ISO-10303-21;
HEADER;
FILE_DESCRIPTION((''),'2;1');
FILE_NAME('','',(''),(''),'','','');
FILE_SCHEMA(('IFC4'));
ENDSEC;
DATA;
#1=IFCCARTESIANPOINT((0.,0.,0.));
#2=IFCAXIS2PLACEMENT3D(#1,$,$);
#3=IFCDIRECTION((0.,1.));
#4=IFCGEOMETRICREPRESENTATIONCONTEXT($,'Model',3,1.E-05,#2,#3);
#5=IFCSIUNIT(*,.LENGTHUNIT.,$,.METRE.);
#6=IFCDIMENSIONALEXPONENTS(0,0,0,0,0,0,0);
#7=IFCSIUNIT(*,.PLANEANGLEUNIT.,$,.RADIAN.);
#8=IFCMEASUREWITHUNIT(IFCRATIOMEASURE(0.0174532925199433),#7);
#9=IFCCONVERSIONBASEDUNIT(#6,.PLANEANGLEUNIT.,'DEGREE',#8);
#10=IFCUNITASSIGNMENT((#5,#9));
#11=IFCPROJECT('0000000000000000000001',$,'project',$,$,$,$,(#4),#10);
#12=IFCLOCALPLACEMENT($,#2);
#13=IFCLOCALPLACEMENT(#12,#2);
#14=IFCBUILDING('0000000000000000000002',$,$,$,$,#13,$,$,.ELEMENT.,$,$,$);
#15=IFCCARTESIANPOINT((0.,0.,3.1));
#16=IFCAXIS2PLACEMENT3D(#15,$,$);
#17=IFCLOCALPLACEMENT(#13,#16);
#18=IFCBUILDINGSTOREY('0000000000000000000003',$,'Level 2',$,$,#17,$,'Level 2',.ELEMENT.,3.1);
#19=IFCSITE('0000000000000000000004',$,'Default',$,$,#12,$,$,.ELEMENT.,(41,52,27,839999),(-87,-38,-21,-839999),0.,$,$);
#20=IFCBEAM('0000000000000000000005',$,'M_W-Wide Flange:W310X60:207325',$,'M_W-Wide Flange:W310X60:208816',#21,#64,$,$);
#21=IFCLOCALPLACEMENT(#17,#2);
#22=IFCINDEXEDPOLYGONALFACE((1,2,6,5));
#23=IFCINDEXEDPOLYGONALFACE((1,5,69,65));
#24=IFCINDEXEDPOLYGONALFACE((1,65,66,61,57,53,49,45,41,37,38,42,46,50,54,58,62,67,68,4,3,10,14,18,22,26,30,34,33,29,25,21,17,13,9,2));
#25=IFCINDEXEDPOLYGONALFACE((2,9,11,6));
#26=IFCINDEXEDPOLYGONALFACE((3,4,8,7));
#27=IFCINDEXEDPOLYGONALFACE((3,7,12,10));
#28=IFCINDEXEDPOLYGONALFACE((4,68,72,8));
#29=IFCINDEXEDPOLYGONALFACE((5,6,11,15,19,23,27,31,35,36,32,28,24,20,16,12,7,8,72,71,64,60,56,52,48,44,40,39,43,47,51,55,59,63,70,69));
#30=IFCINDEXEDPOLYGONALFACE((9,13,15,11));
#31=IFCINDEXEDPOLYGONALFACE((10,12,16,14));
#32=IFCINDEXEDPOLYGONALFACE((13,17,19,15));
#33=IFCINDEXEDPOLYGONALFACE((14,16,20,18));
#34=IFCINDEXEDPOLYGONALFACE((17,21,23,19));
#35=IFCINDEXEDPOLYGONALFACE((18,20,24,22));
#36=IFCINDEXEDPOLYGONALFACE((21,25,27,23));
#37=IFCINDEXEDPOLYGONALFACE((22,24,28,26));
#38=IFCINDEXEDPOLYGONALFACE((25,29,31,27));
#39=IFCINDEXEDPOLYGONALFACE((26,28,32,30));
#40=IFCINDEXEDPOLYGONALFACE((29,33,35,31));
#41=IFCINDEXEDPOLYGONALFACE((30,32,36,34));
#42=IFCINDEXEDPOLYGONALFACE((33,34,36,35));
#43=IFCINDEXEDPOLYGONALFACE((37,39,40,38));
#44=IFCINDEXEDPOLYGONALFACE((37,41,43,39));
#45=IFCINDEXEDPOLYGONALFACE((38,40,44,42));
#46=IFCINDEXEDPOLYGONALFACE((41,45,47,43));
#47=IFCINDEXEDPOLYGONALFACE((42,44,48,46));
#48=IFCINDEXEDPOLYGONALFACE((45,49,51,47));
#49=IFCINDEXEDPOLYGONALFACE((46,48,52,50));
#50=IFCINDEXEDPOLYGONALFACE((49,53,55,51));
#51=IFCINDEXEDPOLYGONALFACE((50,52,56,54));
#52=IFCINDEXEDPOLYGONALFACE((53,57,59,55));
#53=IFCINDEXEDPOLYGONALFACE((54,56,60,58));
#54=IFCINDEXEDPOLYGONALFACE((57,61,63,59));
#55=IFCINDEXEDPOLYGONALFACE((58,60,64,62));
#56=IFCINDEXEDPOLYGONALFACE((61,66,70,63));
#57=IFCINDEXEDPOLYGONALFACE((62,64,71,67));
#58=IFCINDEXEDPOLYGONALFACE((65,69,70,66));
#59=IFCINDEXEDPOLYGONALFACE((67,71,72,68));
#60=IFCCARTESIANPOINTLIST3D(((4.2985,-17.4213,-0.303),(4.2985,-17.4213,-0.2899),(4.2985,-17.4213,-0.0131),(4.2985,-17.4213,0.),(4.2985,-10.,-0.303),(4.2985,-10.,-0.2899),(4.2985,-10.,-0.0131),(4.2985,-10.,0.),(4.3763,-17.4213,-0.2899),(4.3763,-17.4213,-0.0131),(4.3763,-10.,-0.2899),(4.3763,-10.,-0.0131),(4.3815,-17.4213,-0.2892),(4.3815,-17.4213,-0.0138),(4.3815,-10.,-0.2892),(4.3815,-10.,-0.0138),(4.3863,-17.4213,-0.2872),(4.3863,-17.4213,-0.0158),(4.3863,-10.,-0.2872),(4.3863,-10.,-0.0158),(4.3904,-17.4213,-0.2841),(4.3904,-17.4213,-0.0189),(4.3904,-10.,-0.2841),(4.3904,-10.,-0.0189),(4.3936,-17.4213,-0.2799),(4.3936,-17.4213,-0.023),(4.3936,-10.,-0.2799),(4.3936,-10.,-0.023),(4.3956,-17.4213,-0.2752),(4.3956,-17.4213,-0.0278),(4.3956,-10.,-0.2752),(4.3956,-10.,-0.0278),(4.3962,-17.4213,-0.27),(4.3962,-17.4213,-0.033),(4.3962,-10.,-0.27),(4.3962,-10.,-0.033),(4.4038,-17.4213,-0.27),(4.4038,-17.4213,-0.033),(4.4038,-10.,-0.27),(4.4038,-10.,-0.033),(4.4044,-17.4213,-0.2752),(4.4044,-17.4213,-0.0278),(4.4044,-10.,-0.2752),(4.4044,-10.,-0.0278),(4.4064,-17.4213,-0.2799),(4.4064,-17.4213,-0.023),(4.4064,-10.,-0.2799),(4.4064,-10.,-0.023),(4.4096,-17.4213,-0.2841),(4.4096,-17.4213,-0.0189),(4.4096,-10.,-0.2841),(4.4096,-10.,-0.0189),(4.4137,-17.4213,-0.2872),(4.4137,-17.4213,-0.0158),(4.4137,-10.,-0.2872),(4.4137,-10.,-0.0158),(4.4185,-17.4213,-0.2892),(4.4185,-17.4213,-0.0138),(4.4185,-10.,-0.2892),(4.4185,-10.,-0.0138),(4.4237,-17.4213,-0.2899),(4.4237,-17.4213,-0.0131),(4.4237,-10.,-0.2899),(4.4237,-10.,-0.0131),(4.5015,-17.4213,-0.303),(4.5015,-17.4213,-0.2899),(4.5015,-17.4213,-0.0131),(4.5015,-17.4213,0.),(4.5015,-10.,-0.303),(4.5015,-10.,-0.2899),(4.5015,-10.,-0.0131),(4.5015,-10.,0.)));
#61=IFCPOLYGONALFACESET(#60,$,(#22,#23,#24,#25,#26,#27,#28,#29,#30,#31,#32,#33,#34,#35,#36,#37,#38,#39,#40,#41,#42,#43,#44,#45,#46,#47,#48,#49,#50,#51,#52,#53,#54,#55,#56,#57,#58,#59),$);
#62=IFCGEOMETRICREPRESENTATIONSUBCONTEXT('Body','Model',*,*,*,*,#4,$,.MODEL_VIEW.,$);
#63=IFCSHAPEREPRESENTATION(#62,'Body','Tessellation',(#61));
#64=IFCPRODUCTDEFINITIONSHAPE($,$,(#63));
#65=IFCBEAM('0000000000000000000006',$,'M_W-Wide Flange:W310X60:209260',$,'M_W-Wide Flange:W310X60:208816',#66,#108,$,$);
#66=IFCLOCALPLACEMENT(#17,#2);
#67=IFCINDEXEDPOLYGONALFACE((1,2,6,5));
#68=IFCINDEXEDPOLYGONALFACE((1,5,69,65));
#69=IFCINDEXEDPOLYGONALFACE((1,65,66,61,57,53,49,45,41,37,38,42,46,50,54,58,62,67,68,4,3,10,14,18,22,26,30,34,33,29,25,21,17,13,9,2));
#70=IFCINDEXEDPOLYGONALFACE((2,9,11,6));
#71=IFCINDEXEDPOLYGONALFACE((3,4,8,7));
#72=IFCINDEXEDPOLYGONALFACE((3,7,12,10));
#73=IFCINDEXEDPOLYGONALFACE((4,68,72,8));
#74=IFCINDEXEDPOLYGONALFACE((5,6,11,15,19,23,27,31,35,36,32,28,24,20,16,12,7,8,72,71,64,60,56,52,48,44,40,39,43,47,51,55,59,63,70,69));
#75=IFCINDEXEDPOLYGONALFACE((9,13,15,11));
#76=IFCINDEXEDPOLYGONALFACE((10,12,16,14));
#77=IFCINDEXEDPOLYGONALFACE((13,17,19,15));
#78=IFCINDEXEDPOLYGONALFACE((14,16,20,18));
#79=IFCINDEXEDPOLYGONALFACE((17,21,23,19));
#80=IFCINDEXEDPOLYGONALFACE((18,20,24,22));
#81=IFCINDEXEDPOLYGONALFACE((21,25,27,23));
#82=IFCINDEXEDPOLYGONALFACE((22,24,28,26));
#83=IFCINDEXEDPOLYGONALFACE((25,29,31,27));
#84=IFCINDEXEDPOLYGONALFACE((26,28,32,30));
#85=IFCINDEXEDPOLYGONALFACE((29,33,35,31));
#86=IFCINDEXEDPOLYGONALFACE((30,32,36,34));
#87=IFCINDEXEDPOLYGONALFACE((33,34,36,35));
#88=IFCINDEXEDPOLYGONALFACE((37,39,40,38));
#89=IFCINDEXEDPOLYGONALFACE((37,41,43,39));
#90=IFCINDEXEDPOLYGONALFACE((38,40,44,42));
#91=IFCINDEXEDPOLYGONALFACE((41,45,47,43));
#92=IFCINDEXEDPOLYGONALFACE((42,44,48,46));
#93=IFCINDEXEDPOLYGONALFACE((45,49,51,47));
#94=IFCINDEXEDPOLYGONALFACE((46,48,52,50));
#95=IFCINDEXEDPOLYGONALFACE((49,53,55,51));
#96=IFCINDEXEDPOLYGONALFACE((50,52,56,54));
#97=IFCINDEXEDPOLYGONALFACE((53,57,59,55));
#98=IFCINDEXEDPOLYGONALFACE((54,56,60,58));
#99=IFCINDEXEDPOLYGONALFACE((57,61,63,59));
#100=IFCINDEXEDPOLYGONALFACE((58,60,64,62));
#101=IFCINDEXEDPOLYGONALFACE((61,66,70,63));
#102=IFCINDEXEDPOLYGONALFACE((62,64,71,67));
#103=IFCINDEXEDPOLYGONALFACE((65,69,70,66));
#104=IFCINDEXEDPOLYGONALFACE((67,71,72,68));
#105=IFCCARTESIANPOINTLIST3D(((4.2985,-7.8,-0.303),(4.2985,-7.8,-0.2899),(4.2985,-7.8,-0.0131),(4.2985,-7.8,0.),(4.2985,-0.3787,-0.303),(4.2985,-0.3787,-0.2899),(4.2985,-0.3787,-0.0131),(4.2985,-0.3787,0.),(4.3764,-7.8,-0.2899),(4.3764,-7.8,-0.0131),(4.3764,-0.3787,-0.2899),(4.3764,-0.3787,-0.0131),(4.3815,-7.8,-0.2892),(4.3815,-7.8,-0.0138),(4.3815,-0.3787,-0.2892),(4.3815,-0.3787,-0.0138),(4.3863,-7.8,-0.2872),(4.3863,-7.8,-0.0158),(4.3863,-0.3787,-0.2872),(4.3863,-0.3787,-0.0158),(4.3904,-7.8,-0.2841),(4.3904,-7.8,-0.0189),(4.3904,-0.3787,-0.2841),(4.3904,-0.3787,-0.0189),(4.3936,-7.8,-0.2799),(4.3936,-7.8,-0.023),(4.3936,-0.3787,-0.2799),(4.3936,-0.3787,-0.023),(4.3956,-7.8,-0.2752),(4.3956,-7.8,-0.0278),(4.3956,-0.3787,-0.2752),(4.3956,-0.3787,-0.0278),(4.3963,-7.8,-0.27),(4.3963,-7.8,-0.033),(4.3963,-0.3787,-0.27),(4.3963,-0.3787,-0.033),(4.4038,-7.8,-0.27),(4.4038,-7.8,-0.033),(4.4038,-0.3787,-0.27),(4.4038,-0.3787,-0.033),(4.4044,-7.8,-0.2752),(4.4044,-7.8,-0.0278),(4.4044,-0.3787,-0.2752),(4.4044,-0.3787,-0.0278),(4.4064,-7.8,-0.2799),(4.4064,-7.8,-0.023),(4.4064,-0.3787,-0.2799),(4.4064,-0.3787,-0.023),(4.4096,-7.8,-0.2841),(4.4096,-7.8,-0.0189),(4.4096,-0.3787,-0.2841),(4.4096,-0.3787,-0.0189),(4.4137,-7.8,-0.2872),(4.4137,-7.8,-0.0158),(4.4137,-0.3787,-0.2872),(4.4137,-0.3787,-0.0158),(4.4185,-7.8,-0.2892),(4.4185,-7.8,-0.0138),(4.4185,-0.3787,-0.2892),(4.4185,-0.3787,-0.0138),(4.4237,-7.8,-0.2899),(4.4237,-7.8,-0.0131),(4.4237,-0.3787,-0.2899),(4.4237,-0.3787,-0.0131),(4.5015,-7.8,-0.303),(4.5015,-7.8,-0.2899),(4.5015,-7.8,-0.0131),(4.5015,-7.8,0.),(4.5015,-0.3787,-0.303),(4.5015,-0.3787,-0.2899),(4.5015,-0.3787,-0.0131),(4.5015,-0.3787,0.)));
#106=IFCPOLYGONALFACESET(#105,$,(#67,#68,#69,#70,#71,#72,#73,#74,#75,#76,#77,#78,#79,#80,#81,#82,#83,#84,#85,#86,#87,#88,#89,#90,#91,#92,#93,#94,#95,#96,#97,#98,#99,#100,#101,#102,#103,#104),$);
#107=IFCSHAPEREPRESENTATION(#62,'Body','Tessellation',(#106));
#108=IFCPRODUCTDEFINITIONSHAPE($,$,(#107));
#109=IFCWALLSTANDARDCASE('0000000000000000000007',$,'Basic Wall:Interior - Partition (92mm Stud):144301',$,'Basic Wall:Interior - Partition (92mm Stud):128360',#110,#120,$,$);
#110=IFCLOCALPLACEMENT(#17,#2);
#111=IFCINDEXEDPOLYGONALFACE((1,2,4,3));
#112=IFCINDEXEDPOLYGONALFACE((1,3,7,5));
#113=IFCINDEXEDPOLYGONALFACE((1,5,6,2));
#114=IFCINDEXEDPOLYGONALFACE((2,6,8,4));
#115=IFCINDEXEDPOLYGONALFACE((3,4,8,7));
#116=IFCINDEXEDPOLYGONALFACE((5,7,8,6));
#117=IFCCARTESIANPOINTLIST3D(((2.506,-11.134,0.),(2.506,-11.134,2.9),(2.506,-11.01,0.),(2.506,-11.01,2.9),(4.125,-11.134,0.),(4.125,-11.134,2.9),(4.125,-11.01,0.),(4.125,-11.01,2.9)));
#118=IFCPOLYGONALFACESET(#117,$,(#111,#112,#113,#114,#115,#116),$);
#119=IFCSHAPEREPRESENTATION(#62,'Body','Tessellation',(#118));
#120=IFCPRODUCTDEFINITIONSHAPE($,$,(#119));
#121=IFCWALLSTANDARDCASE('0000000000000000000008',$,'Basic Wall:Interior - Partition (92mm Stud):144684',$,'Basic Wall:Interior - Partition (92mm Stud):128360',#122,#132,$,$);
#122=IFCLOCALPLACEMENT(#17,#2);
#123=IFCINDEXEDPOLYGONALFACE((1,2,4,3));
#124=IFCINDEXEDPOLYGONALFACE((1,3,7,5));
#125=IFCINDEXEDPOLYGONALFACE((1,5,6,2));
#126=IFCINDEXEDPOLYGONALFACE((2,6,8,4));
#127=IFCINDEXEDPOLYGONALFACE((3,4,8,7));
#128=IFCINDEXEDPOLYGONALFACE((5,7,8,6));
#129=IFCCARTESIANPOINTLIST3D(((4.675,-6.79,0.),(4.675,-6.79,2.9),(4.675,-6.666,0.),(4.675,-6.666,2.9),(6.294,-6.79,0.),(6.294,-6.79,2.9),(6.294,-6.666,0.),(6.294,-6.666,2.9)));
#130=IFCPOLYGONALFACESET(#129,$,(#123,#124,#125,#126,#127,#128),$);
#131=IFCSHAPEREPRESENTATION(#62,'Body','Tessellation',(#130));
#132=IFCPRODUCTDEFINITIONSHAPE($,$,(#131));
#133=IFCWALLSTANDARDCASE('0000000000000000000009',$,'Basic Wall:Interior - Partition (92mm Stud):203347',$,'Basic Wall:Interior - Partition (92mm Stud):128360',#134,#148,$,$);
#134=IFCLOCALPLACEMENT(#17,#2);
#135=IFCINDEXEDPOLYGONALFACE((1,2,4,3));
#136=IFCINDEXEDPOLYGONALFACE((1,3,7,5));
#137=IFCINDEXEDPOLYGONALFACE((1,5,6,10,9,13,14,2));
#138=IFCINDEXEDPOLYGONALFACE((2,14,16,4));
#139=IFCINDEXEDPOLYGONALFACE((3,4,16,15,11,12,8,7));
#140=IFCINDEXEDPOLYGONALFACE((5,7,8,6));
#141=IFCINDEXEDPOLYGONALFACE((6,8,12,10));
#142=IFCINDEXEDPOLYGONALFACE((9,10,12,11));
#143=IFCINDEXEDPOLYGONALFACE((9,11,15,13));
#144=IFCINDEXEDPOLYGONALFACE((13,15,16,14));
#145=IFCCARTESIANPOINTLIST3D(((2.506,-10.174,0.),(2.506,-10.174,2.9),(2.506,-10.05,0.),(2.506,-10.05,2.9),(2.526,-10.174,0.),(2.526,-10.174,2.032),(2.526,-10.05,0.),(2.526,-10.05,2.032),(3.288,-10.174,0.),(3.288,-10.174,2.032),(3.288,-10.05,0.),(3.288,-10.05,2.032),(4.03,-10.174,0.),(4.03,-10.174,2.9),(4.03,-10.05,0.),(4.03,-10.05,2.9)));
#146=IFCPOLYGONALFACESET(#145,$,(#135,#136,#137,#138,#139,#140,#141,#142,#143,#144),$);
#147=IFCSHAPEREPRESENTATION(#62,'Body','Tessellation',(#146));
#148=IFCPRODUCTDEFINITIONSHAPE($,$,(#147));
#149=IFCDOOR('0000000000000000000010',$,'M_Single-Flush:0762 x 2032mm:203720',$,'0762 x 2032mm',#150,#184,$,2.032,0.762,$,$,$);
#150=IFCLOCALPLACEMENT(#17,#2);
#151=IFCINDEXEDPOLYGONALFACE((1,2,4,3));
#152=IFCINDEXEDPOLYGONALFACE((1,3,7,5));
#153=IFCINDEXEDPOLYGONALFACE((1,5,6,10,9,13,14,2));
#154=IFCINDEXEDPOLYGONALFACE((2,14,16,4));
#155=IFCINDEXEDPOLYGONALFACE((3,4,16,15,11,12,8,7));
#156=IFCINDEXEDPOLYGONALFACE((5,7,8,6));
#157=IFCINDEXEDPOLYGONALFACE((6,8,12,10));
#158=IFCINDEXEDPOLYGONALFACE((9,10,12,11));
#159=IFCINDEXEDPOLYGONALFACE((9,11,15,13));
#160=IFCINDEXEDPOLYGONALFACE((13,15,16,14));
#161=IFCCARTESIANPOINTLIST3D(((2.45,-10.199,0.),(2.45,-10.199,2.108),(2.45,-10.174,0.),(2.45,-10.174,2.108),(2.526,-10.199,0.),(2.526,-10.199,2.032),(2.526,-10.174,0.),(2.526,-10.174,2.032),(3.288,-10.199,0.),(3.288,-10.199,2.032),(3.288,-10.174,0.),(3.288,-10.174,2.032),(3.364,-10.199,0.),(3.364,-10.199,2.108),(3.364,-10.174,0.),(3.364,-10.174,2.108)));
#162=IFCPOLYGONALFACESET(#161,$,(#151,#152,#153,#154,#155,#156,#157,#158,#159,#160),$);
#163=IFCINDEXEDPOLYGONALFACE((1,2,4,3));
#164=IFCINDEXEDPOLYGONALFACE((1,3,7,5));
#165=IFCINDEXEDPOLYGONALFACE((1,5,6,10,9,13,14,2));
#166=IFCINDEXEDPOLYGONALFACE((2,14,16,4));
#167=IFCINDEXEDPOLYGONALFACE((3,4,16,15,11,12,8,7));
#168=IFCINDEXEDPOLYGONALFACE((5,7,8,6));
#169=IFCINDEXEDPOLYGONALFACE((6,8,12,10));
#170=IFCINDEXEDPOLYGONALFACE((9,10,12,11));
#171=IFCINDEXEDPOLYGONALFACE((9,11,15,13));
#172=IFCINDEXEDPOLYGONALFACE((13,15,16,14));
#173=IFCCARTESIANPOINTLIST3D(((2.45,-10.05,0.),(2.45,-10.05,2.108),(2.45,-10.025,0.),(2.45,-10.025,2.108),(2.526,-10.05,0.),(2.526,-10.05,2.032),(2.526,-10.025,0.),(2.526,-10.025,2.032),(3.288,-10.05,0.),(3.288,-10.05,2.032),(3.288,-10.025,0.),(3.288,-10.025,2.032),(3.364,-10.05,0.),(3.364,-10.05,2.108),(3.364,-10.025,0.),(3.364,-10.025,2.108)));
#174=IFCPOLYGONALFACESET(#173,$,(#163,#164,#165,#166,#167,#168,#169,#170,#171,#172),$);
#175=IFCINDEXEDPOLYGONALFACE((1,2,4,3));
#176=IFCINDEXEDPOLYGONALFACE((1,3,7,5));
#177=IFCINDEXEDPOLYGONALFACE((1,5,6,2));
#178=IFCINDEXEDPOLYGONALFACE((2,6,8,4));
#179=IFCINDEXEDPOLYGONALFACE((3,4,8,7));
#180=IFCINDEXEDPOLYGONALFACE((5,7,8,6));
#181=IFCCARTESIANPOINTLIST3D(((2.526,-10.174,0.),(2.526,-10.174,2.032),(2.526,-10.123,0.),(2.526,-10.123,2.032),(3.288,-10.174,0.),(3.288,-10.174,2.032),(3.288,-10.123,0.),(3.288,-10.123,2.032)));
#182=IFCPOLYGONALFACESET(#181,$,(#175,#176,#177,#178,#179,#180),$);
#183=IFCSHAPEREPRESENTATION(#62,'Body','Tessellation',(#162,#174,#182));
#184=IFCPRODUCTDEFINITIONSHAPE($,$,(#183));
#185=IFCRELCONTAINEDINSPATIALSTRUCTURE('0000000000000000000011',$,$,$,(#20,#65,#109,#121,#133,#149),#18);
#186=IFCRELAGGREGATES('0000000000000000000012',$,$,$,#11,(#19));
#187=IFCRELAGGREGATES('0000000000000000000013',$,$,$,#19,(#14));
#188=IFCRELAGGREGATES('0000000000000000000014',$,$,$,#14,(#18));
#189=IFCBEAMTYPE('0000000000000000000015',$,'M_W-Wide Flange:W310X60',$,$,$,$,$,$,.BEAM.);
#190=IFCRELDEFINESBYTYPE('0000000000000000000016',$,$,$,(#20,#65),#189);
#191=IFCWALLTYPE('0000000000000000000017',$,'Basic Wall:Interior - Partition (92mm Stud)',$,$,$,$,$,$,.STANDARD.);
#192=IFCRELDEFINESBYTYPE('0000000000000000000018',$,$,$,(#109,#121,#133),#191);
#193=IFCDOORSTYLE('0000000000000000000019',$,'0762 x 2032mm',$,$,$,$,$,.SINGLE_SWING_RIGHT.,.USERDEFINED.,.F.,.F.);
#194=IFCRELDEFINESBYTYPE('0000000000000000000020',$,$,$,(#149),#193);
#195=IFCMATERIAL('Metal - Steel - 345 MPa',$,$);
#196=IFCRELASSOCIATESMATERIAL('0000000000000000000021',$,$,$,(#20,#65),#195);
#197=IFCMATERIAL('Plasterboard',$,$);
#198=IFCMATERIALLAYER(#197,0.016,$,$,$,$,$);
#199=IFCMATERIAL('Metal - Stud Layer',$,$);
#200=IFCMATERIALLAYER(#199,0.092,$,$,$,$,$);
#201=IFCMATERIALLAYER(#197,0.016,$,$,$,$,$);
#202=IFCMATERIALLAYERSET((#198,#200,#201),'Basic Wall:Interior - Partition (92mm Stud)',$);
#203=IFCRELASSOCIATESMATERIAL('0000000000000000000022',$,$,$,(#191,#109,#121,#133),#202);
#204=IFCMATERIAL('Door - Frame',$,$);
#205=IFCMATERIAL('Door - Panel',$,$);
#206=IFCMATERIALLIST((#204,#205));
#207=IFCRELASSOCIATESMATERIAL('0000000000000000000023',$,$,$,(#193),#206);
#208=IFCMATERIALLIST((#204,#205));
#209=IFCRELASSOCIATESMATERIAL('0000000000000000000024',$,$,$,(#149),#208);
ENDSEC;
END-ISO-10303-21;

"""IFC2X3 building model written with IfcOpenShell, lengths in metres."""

from ifc_helpers import new_model, entity, si_unit, converted_unit, direction, frame, frame_2d, origin, origin_2d_with_axis, place, context, subcontext, project, spatial, polyline, rectangle, i_section, outline, extrude, source, transform, mapped, material, material_list, layer, layer_set, layer_usage, type_object, type_shapes, element, fill, save


model = new_model("IFC2X3")

# Units and contexts
model_context = context("Model", 3, precision=1e-05, world=origin(), true_north=direction((0.0, 1.0)))
body_context = subcontext(model_context, "Body", "Model", "MODEL_VIEW")
ifc_project = project(units=[si_unit("LENGTHUNIT", "METRE"), converted_unit("PLANEANGLEUNIT", "DEGREE", entity("IfcRatioMeasure", 0.0174532925199433), si_unit("PLANEANGLEUNIT", "RADIAN"), dimensions=[0, 0, 0, 0, 0, 0, 0])], contexts=[model_context])

# Site, building, storey
site_placement = place(None, origin())
site = spatial("IfcSite", under=ifc_project, at=site_placement, Name="Default", CompositionType="ELEMENT", RefLatitude=(41, 52, 27, 839999), RefLongitude=(-87, -38, -21, -839999), RefElevation=0.0)
building_placement = place(site_placement, origin())
building = spatial("IfcBuilding", under=site, at=building_placement, CompositionType="ELEMENT")
storey_placement = place(building_placement, frame((0.0, 0.0, 3.1)))
storey = spatial("IfcBuildingStorey", under=building, at=storey_placement, Name="Level 2", LongName="Level 2", CompositionType="ELEMENT", Elevation=3.1)

# Beams
ifc_material_1 = material(Name="Metal - Steel - 345 MPa")
beam_type = type_object("IfcBeamType", Name="M_W-Wide Flange:W310X60", PredefinedType="BEAM")
beam_1_placement = place(storey_placement, frame((4.4, -10.0, 0.0), z_axis=(0.0, 0.0, 1.0), x_axis=(0.0, -1.0, 0.0)))
element("IfcBeam", 1, at=beam_1_placement, inside=storey, type_object=beam_type, material=ifc_material_1, Name="M_W-Wide Flange:W310X60:207325", ObjectType="M_W-Wide Flange:W310X60:208816", context=body_context, shape_type="SweptSolid", body=[
    extrude(i_section(OverallWidth=0.203, OverallDepth=0.303, WebThickness=0.0075, FlangeThickness=0.0131, FilletRadius=0.0199, at=frame_2d((0.0, 0.0), x_axis=(0.0, 1.0))), frame((0.0, 0.0, -0.1515), z_axis=(1.0, 0.0, 0.0), x_axis=(0.0, 0.0, -1.0)), (0.0, 0.0, 1.0), 7.4213),
])
beam_2_placement = place(storey_placement, frame((4.4, -7.8, 0.0), z_axis=(0.0, 0.0, 1.0), x_axis=(0.0, 1.0, 0.0)))
element("IfcBeam", 2, at=beam_2_placement, inside=storey, type_object=beam_type, material=ifc_material_1, Name="M_W-Wide Flange:W310X60:209260", ObjectType="M_W-Wide Flange:W310X60:208816", context=body_context, shape_type="SweptSolid", body=[
    extrude(i_section(OverallWidth=0.203, OverallDepth=0.303, WebThickness=0.0075, FlangeThickness=0.0131, FilletRadius=0.0199, at=frame_2d((0.0, 0.0), x_axis=(0.0, 1.0))), frame((0.0, 0.0, -0.1515), z_axis=(1.0, 0.0, 0.0), x_axis=(0.0, 0.0, -1.0)), (0.0, 0.0, 1.0), 7.4213),
])

# Walls
ifc_material_2 = material(Name="Plasterboard")
ifc_layer_1 = layer(ifc_material_2, 0.016)
ifc_material_3 = material(Name="Metal - Stud Layer")
ifc_layer_2 = layer(ifc_material_3, 0.092)
ifc_layer_3 = layer(ifc_material_2, 0.016)
ifc_layer_set_1 = layer_set([ifc_layer_1, ifc_layer_2, ifc_layer_3], Name="Basic Wall:Interior - Partition (92mm Stud)")
ifc_layer_usage_1 = layer_usage(ifc_layer_set_1, "AXIS2", "NEGATIVE", 0.062)
wall_type_1 = type_object("IfcWallType", Name="Basic Wall:Interior - Partition (92mm Stud)", PredefinedType="STANDARD", material=ifc_layer_set_1)
wall_1_placement = place(storey_placement, frame((4.125, -11.072, 0.0), z_axis=(0.0, 0.0, 1.0), x_axis=(-1.0, 0.0, 0.0)))
element("IfcWallStandardCase", 3, at=wall_1_placement, inside=storey, type_object=wall_type_1, material=ifc_layer_usage_1, Name="Basic Wall:Interior - Partition (92mm Stud):144301", ObjectType="Basic Wall:Interior - Partition (92mm Stud):128360", context=body_context, shape_type="SweptSolid", body=[
    extrude(rectangle(XDim=1.619, YDim=0.124, at=frame_2d((0.8095, 0.0), x_axis=(-1.0, 0.0))), origin(), (0.0, 0.0, 1.0), 2.9),
])
ifc_layer_usage_2 = layer_usage(ifc_layer_set_1, "AXIS2", "NEGATIVE", 0.062)
wall_2_placement = place(storey_placement, frame((4.675, -6.728, 0.0)))
element("IfcWallStandardCase", 4, at=wall_2_placement, inside=storey, type_object=wall_type_1, material=ifc_layer_usage_2, Name="Basic Wall:Interior - Partition (92mm Stud):144684", ObjectType="Basic Wall:Interior - Partition (92mm Stud):128360", context=body_context, shape_type="SweptSolid", body=[
    extrude(rectangle(XDim=1.619, YDim=0.124, at=frame_2d((0.8095, 0.0), x_axis=(-1.0, 0.0))), origin(), (0.0, 0.0, 1.0), 2.9),
])

# Wall, opening, door
ifc_layer_usage_3 = layer_usage(ifc_layer_set_1, "AXIS2", "NEGATIVE", 0.062)
wall_3_placement = place(storey_placement, frame((4.03, -10.112, 0.0), z_axis=(0.0, 0.0, 1.0), x_axis=(-1.0, 0.0, 0.0)))
wall_3 = element("IfcWallStandardCase", 5, at=wall_3_placement, inside=storey, type_object=wall_type_1, material=ifc_layer_usage_3, Name="Basic Wall:Interior - Partition (92mm Stud):203347", ObjectType="Basic Wall:Interior - Partition (92mm Stud):128360", context=body_context, shape_type="SweptSolid", body=[
    extrude(rectangle(XDim=1.524, YDim=0.124, at=frame_2d((0.762, 0.0), x_axis=(-1.0, 0.0))), origin(), (0.0, 0.0, 1.0), 2.9),
])
opening_1_placement = place(wall_3_placement, frame((0.742, -0.062, 0.0)))
opening_1 = element("IfcOpeningElement", 6, at=opening_1_placement, cuts=wall_3, ObjectType="Opening", context=body_context, shape_type="SweptSolid", body=[
    extrude(rectangle(XDim=0.762, YDim=2.032, at=frame_2d((1.016, 0.381), x_axis=(0.0, 1.0))), frame((0.0, 0.0, 0.0), z_axis=(0.0, 1.0, 0.0), x_axis=(0.0, 0.0, 1.0)), (0.0, 0.0, 1.0), 0.124),
])
ifc_material_4 = material(Name="Door - Frame")
ifc_material_5 = material(Name="Door - Panel")
ifc_material_list_1 = material_list([ifc_material_4, ifc_material_5])
ifc_material_list_2 = material_list([ifc_material_4, ifc_material_5])
door_style = type_object("IfcDoorStyle", Name="0762 x 2032mm", ConstructionType="USERDEFINED", OperationType="SINGLE_SWING_RIGHT", ParameterTakesPrecedence=False, Sizeable=False, material=ifc_material_list_2)
shared_shape_1 = source(origin(), body_context, "Body", "SweptSolid", [
    extrude(outline(polyline([(-0.457, -1.073), (0.457, -1.073), (0.457, 1.035), (0.381, 1.035), (0.381, -0.997), (-0.381, -0.997), (-0.381, 1.035), (-0.457, 1.035), (-0.457, -1.073)])), frame((0.381, 0.124, 1.035), z_axis=(0.0, 1.0, 0.0), x_axis=(1.0, 0.0, 0.0)), (0.0, 0.0, 1.0), 0.025),
    extrude(outline(polyline([(-1.073, -0.457), (1.035, -0.457), (1.035, -0.381), (-0.997, -0.381), (-0.997, 0.381), (1.035, 0.381), (1.035, 0.457), (-1.073, 0.457), (-1.073, -0.457)])), frame((0.381, -0.025, 1.035), z_axis=(0.0, 1.0, 0.0), x_axis=(0.0, 0.0, -1.0)), (0.0, 0.0, 1.0), 0.025),
    extrude(rectangle(XDim=0.051, YDim=0.762, at=origin_2d_with_axis()), frame((0.381, 0.0985, 0.0), z_axis=(0.0, 0.0, 1.0), x_axis=(0.0, 1.0, 0.0)), (0.0, 0.0, 1.0), 2.032),
])
type_shapes(door_style, [shared_shape_1])
door_1_placement = place(opening_1_placement, origin())
door_1 = element("IfcDoor", 7, at=door_1_placement, inside=storey, type_object=door_style, material=ifc_material_list_1, Name="M_Single-Flush:0762 x 2032mm:203720", ObjectType="0762 x 2032mm", OverallHeight=2.032, OverallWidth=0.762, context=body_context, shape_type="MappedRepresentation", body=[
    mapped(shared_shape_1, transform((0.0, 0.0, 0.0), scale=1.0)),
])
fill(opening_1, door_1)

save(model, "model.ifc")
